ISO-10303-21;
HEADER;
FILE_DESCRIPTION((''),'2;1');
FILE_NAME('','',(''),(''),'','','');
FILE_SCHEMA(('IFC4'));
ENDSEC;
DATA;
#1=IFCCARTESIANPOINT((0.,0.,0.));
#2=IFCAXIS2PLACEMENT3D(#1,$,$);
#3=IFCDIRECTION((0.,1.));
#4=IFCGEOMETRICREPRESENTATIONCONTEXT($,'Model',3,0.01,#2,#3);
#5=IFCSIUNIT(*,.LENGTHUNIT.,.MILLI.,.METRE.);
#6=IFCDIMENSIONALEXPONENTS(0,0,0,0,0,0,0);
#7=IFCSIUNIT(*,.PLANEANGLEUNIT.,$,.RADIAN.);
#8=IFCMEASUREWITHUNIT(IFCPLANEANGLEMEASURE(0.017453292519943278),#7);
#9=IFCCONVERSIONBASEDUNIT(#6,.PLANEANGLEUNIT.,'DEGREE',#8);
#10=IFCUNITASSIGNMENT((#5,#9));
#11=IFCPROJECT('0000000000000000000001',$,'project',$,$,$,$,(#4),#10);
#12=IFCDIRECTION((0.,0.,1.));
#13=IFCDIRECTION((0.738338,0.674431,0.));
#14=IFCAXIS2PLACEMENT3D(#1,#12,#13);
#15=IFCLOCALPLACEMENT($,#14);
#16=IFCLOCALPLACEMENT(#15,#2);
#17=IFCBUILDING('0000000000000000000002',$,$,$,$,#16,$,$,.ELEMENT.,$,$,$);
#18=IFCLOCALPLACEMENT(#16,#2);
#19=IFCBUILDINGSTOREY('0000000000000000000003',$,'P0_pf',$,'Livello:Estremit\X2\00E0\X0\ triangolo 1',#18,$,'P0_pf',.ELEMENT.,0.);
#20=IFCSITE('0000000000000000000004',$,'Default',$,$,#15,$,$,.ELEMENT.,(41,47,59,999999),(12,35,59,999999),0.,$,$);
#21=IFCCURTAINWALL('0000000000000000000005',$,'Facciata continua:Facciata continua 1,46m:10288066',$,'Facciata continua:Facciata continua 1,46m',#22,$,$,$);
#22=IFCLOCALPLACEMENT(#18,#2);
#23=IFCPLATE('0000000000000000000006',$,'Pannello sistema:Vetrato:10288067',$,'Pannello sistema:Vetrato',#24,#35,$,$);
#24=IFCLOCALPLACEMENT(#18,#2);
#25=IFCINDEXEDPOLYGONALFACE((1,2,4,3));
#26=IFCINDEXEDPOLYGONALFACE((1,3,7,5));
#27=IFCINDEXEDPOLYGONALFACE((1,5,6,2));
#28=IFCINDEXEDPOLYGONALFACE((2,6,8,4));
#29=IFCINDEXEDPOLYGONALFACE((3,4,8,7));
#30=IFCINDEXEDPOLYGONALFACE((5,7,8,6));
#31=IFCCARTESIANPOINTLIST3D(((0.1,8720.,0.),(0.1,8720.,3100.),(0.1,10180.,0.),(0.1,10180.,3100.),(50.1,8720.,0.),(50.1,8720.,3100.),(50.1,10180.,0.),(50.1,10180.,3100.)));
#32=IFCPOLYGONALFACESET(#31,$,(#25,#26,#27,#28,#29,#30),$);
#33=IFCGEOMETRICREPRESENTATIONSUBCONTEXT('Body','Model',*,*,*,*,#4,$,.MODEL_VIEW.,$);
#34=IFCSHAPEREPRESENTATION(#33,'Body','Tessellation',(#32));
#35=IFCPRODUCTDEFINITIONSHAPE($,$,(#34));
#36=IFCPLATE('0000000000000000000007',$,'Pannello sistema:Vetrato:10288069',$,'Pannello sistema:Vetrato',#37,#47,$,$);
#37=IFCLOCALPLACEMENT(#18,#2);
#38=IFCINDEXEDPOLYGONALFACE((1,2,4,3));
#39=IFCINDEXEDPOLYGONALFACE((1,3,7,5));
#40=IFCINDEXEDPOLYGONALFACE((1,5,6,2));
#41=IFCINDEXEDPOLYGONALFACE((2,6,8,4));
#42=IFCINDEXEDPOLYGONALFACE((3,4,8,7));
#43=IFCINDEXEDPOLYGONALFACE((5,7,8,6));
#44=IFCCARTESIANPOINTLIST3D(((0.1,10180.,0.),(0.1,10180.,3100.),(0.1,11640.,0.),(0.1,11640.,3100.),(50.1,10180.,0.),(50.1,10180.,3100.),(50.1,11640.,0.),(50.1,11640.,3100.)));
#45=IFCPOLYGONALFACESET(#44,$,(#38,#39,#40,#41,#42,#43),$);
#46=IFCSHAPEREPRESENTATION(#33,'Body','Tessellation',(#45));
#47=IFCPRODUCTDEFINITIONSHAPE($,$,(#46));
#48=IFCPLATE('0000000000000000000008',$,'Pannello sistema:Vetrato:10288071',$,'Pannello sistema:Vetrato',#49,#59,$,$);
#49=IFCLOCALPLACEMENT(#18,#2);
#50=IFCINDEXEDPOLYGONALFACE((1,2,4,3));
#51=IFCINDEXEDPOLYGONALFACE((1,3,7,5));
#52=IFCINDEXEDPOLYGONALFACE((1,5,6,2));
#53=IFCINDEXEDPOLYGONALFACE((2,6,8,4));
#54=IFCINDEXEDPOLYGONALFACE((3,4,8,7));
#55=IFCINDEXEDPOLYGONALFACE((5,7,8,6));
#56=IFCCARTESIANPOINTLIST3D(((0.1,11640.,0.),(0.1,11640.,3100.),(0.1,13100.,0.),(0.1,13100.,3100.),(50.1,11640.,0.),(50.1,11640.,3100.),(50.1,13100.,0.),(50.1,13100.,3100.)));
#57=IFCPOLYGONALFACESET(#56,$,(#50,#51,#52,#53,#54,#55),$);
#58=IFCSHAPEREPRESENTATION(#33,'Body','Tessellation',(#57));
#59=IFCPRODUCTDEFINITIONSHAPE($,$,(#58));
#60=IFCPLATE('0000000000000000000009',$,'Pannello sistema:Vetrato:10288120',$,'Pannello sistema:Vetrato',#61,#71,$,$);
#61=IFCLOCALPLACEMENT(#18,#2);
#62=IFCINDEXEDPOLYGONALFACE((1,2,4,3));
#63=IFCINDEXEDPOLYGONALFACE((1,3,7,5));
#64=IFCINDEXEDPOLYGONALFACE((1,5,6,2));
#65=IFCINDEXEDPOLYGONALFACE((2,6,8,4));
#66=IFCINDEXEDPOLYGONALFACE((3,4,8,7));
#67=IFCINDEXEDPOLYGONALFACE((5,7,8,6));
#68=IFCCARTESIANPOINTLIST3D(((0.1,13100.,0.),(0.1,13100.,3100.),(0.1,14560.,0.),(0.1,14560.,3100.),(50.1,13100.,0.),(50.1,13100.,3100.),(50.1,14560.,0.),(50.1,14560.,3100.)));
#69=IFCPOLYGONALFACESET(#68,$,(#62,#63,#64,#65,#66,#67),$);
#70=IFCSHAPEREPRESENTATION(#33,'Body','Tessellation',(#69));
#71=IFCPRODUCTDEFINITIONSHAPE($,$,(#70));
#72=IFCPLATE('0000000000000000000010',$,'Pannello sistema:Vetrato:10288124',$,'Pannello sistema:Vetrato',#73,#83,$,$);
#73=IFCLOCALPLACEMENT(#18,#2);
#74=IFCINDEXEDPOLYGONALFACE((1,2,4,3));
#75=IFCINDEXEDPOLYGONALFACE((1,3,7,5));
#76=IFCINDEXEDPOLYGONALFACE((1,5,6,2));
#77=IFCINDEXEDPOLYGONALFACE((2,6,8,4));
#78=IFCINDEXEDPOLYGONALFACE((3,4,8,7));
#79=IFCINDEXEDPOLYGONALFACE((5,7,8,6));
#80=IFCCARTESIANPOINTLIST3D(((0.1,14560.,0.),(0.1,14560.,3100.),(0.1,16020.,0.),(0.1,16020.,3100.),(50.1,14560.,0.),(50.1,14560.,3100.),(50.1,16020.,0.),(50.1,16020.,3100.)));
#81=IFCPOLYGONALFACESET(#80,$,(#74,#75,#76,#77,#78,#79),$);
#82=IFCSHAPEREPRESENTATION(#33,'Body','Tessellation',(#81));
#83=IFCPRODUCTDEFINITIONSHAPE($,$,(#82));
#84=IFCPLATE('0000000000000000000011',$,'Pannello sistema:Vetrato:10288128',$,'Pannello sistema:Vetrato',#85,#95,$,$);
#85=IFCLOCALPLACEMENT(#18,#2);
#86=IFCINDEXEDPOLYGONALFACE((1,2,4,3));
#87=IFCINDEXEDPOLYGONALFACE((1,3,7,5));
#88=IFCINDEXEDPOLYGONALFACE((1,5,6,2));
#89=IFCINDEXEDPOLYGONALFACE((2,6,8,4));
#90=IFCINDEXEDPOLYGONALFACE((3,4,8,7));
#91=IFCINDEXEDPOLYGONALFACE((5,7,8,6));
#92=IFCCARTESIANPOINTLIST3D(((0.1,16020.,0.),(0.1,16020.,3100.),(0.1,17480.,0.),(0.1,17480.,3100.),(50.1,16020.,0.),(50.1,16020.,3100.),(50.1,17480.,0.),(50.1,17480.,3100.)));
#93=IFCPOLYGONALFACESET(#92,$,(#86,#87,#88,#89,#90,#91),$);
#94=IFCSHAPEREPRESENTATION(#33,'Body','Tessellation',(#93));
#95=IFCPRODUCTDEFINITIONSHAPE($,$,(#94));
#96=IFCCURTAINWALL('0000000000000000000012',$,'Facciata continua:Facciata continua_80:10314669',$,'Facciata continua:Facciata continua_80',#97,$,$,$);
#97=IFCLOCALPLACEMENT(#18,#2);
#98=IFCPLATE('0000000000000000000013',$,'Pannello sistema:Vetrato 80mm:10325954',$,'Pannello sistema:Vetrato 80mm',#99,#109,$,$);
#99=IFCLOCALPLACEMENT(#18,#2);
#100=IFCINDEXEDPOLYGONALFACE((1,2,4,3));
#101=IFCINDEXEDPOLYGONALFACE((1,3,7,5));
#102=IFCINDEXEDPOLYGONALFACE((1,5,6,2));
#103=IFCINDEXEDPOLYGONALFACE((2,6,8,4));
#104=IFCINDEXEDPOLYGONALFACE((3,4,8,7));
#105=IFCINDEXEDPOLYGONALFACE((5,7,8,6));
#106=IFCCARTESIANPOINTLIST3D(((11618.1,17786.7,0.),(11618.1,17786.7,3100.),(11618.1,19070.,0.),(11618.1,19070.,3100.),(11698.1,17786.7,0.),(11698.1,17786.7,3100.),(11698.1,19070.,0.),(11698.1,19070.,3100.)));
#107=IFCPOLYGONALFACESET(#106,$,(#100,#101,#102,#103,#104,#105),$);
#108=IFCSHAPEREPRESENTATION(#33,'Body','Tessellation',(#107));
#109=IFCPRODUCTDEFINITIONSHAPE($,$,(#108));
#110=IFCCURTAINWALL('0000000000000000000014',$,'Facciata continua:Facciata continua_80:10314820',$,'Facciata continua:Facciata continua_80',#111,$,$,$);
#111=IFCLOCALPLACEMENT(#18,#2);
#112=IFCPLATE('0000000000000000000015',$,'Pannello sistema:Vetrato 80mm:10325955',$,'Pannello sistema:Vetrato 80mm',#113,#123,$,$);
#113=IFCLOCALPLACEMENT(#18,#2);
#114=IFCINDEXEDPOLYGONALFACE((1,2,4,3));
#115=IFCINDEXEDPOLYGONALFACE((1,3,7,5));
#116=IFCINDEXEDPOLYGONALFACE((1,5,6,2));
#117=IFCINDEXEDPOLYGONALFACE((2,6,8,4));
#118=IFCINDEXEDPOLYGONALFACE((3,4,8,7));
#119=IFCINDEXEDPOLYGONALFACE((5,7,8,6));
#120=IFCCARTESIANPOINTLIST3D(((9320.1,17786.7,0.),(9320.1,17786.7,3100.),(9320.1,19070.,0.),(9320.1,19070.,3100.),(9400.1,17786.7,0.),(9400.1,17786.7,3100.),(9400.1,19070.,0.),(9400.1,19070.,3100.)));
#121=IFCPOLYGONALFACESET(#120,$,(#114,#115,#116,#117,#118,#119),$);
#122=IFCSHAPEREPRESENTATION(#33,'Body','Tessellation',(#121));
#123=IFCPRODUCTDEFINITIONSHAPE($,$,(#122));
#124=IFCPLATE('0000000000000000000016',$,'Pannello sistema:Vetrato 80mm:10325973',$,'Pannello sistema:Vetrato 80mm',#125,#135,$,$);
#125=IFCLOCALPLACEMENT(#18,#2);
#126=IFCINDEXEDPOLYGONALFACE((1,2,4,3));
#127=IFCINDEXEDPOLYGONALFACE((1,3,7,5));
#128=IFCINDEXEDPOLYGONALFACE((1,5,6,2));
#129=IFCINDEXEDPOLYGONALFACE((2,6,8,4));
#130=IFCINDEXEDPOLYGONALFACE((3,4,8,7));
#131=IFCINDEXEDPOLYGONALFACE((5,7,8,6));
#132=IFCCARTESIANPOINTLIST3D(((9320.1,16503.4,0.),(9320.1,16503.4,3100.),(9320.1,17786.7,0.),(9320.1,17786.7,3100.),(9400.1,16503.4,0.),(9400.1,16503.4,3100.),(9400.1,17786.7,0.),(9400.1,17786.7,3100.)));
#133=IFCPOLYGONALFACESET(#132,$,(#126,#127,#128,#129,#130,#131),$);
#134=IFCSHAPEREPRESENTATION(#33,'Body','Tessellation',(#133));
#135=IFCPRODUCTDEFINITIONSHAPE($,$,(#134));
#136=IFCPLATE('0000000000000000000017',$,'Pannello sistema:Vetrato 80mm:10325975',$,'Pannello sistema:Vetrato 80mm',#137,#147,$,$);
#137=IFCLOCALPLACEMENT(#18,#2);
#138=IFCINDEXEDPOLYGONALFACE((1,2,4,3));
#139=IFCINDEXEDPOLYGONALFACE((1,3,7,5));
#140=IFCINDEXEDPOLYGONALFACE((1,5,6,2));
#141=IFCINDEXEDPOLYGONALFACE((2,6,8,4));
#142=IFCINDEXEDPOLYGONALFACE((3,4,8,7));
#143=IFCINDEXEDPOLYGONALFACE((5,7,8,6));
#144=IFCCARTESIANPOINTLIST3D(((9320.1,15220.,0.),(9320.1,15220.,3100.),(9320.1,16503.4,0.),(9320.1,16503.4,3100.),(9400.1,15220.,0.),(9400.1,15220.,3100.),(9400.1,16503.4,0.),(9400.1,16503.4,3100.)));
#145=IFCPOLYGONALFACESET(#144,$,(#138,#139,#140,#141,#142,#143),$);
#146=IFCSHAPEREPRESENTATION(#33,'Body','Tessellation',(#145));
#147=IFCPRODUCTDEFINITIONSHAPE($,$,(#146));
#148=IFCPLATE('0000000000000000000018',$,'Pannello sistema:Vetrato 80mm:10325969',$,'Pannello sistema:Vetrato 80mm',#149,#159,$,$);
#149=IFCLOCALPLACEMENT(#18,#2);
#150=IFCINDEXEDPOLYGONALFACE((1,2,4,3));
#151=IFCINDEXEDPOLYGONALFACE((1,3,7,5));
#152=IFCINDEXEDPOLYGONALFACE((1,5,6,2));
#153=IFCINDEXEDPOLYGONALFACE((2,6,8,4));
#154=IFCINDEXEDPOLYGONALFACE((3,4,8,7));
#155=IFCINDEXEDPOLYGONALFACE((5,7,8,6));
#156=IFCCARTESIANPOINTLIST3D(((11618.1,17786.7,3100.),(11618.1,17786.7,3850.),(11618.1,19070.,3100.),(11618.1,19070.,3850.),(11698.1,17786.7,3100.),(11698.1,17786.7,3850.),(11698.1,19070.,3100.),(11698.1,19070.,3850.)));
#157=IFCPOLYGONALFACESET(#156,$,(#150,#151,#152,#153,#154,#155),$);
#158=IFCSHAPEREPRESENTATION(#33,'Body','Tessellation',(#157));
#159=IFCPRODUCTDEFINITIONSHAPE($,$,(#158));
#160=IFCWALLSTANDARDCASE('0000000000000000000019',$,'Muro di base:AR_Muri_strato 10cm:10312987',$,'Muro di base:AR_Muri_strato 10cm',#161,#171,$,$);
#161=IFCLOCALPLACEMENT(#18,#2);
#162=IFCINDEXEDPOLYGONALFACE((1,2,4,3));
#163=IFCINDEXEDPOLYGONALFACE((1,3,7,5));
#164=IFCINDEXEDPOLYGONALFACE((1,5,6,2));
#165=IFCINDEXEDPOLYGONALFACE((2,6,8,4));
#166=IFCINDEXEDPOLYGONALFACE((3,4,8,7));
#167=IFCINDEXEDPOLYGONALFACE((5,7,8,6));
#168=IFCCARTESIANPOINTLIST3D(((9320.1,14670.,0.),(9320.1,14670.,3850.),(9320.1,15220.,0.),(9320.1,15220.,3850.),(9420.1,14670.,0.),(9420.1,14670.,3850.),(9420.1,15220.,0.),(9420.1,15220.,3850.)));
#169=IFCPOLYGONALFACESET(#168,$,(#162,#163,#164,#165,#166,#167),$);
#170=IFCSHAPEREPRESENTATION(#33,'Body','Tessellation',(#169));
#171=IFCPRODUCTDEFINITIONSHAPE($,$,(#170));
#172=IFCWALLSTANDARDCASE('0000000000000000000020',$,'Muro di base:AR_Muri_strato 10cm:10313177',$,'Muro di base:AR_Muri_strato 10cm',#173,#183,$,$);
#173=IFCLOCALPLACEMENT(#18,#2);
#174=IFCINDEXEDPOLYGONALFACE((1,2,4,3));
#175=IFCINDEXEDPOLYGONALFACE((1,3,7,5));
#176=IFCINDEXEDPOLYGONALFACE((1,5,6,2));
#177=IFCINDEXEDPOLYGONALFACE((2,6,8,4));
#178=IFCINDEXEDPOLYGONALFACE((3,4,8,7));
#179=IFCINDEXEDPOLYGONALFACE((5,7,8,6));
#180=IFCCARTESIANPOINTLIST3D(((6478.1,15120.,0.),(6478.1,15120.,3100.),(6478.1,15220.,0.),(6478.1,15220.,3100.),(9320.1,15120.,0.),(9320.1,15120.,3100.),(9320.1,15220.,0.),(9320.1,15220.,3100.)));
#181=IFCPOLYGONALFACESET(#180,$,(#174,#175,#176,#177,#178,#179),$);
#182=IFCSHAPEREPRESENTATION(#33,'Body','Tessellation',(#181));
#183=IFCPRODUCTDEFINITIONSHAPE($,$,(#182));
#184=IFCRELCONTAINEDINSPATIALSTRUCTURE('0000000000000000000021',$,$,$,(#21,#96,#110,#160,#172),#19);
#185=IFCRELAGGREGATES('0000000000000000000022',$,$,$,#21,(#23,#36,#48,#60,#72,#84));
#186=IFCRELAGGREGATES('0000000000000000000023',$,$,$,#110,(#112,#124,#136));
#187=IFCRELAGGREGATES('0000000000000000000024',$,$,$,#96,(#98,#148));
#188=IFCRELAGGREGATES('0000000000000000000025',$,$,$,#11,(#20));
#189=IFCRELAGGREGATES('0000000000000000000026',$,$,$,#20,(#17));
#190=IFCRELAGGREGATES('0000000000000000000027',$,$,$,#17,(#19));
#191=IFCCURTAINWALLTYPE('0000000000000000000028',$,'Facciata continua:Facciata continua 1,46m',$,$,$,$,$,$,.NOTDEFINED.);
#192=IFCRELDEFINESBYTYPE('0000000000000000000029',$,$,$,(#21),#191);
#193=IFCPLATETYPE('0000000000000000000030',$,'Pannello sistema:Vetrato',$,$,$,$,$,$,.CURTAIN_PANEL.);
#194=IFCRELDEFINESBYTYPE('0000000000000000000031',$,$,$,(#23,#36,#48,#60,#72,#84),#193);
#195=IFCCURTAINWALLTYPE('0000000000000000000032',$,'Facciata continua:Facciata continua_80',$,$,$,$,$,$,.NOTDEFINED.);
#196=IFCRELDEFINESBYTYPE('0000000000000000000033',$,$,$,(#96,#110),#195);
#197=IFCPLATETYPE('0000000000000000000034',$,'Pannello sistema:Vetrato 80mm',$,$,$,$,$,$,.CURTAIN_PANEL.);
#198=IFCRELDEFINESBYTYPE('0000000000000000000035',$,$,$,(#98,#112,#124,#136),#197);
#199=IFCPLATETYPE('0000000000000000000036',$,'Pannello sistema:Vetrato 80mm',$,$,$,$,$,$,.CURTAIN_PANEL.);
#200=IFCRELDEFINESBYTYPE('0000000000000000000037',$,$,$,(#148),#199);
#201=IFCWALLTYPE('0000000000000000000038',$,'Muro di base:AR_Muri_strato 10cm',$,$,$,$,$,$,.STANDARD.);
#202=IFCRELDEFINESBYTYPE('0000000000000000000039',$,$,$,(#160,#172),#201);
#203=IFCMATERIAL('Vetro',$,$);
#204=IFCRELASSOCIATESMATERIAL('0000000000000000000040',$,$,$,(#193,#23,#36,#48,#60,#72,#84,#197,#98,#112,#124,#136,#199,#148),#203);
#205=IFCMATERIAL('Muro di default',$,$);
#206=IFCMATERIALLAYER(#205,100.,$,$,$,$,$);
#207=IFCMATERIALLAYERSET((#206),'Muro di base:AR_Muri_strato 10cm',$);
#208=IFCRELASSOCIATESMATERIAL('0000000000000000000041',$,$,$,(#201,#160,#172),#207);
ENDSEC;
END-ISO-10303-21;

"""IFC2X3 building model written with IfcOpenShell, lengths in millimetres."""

from ifc_helpers import new_model, entity, si_unit, converted_unit, direction, frame, frame_2d, origin, origin_2d_with_axis, place, context, subcontext, project, spatial, rectangle, extrude, source, transform, mapped, material, layer, layer_set, layer_usage, type_object, type_shapes, element, aggregate, save


model = new_model("IFC2X3")

# Units and contexts
model_context = context("Model", 3, precision=0.01, world=origin(), true_north=direction((0.0, 1.0)))
body_context = subcontext(model_context, "Body", "Model", "MODEL_VIEW")
ifc_project = project(units=[si_unit("LENGTHUNIT", "METRE", prefix="MILLI"), converted_unit("PLANEANGLEUNIT", "DEGREE", entity("IfcPlaneAngleMeasure", 0.017453292519943278), si_unit("PLANEANGLEUNIT", "RADIAN"), dimensions=[0, 0, 0, 0, 0, 0, 0])], contexts=[model_context])

# Site, building, storey
site_placement = place(None, frame((0.0, 0.0, 0.0), z_axis=(0.0, 0.0, 1.0), x_axis=(0.738338, 0.674431, 0.0)))
site = spatial("IfcSite", under=ifc_project, at=site_placement, Name="Default", CompositionType="ELEMENT", RefLatitude=(41, 47, 59, 999999), RefLongitude=(12, 35, 59, 999999), RefElevation=0.0)
building_placement = place(site_placement, origin())
building = spatial("IfcBuilding", under=site, at=building_placement, CompositionType="ELEMENT")
storey_placement = place(building_placement, origin())
storey = spatial("IfcBuildingStorey", under=building, at=storey_placement, Name="P0_pf", ObjectType="Livello:Estremità triangolo 1", LongName="P0_pf", CompositionType="ELEMENT", Elevation=0.0)

# Curtain wall, plates
curtain_wall_type_1 = type_object("IfcCurtainWallType", Name="Facciata continua:Facciata continua 1,46m", PredefinedType="NOTDEFINED")
curtain_wall_1_placement = place(storey_placement, origin())
curtain_wall_1 = element("IfcCurtainWall", 1, at=curtain_wall_1_placement, inside=storey, type_object=curtain_wall_type_1, Name="Facciata continua:Facciata continua 1,46m:10288066", ObjectType="Facciata continua:Facciata continua 1,46m")
ifc_material_1 = material(Name="Vetro")
plate_type_1 = type_object("IfcPlateType", Name="Pannello sistema:Vetrato", PredefinedType="CURTAIN_PANEL", material=ifc_material_1)
shared_shape_1 = source(origin(), body_context, "Body", "SweptSolid", [
    extrude(rectangle(XDim=50.0, YDim=1460.0, at=origin_2d_with_axis()), frame((0.0, -25.0, 0.0), z_axis=(0.0, 0.0, 1.0), x_axis=(0.0, 1.0, 0.0)), (0.0, 0.0, 1.0), 3100.0),
])
type_shapes(plate_type_1, [shared_shape_1])
plate_1_placement = place(curtain_wall_1_placement, frame((0.1, 9450.0, 0.0), z_axis=(0.0, 0.0, 1.0), x_axis=(0.0, 1.0, 0.0)))
plate_1 = element("IfcPlate", 2, at=plate_1_placement, type_object=plate_type_1, material=ifc_material_1, Name="Pannello sistema:Vetrato:10288067", ObjectType="Pannello sistema:Vetrato", context=body_context, shape_type="MappedRepresentation", body=[
    mapped(shared_shape_1, transform((0.0, 0.0, 0.0), scale=1.0)),
])
plate_2_placement = place(curtain_wall_1_placement, frame((0.1, 10910.0, 0.0), z_axis=(0.0, 0.0, 1.0), x_axis=(0.0, 1.0, 0.0)))
plate_2 = element("IfcPlate", 3, at=plate_2_placement, type_object=plate_type_1, material=ifc_material_1, Name="Pannello sistema:Vetrato:10288069", ObjectType="Pannello sistema:Vetrato", context=body_context, shape_type="MappedRepresentation", body=[
    mapped(shared_shape_1, transform((0.0, 0.0, 0.0), scale=1.0)),
])
plate_3_placement = place(curtain_wall_1_placement, frame((0.1, 12370.0, 0.0), z_axis=(0.0, 0.0, 1.0), x_axis=(0.0, 1.0, 0.0)))
plate_3 = element("IfcPlate", 4, at=plate_3_placement, type_object=plate_type_1, material=ifc_material_1, Name="Pannello sistema:Vetrato:10288071", ObjectType="Pannello sistema:Vetrato", context=body_context, shape_type="MappedRepresentation", body=[
    mapped(shared_shape_1, transform((0.0, 0.0, 0.0), scale=1.0)),
])
plate_4_placement = place(curtain_wall_1_placement, frame((0.1, 13830.0, 0.0), z_axis=(0.0, 0.0, 1.0), x_axis=(0.0, 1.0, 0.0)))
plate_4 = element("IfcPlate", 5, at=plate_4_placement, type_object=plate_type_1, material=ifc_material_1, Name="Pannello sistema:Vetrato:10288120", ObjectType="Pannello sistema:Vetrato", context=body_context, shape_type="MappedRepresentation", body=[
    mapped(shared_shape_1, transform((0.0, 0.0, 0.0), scale=1.0)),
])
plate_5_placement = place(curtain_wall_1_placement, frame((0.1, 15290.0, 0.0), z_axis=(0.0, 0.0, 1.0), x_axis=(0.0, 1.0, 0.0)))
plate_5 = element("IfcPlate", 6, at=plate_5_placement, type_object=plate_type_1, material=ifc_material_1, Name="Pannello sistema:Vetrato:10288124", ObjectType="Pannello sistema:Vetrato", context=body_context, shape_type="MappedRepresentation", body=[
    mapped(shared_shape_1, transform((0.0, 0.0, 0.0), scale=1.0)),
])
plate_6_placement = place(curtain_wall_1_placement, frame((0.1, 16750.0, 0.0), z_axis=(0.0, 0.0, 1.0), x_axis=(0.0, 1.0, 0.0)))
plate_6 = element("IfcPlate", 7, at=plate_6_placement, type_object=plate_type_1, material=ifc_material_1, Name="Pannello sistema:Vetrato:10288128", ObjectType="Pannello sistema:Vetrato", context=body_context, shape_type="MappedRepresentation", body=[
    mapped(shared_shape_1, transform((0.0, 0.0, 0.0), scale=1.0)),
])
aggregate(curtain_wall_1, [plate_1, plate_2, plate_3, plate_4, plate_5, plate_6])

# Curtain wall, plate
curtain_wall_type_2 = type_object("IfcCurtainWallType", Name="Facciata continua:Facciata continua_80", PredefinedType="NOTDEFINED")
curtain_wall_2_placement = place(storey_placement, origin())
curtain_wall_2 = element("IfcCurtainWall", 8, at=curtain_wall_2_placement, inside=storey, type_object=curtain_wall_type_2, Name="Facciata continua:Facciata continua_80:10314669", ObjectType="Facciata continua:Facciata continua_80")
plate_type_2 = type_object("IfcPlateType", Name="Pannello sistema:Vetrato 80mm", PredefinedType="CURTAIN_PANEL", material=ifc_material_1)
shared_shape_2 = source(origin(), body_context, "Body", "SweptSolid", [
    extrude(rectangle(XDim=80.0, YDim=1283.3, at=origin_2d_with_axis()), frame((0.0, -40.0, 0.0), z_axis=(0.0, 0.0, 1.0), x_axis=(0.0, 1.0, 0.0)), (0.0, 0.0, 1.0), 3100.0),
])
type_shapes(plate_type_2, [shared_shape_2])
plate_7_placement = place(curtain_wall_2_placement, frame((11698.1, 18428.4, 0.0), z_axis=(0.0, 0.0, 1.0), x_axis=(0.0, -1.0, 0.0)))
plate_7 = element("IfcPlate", 9, at=plate_7_placement, type_object=plate_type_2, material=ifc_material_1, Name="Pannello sistema:Vetrato 80mm:10325954", ObjectType="Pannello sistema:Vetrato 80mm", context=body_context, shape_type="MappedRepresentation", body=[
    mapped(shared_shape_2, transform((0.0, 0.0, 0.0), scale=1.0)),
])

# Curtain wall, plates
curtain_wall_3_placement = place(storey_placement, origin())
curtain_wall_3 = element("IfcCurtainWall", 10, at=curtain_wall_3_placement, inside=storey, type_object=curtain_wall_type_2, Name="Facciata continua:Facciata continua_80:10314820", ObjectType="Facciata continua:Facciata continua_80")
plate_8_placement = place(curtain_wall_3_placement, frame((9400.1, 18428.4, 0.0), z_axis=(0.0, 0.0, 1.0), x_axis=(0.0, -1.0, 0.0)))
plate_8 = element("IfcPlate", 11, at=plate_8_placement, type_object=plate_type_2, material=ifc_material_1, Name="Pannello sistema:Vetrato 80mm:10325955", ObjectType="Pannello sistema:Vetrato 80mm", context=body_context, shape_type="MappedRepresentation", body=[
    mapped(shared_shape_2, transform((0.0, 0.0, 0.0), scale=1.0)),
])
plate_9_placement = place(curtain_wall_3_placement, frame((9400.1, 17145.0, 0.0), z_axis=(0.0, 0.0, 1.0), x_axis=(0.0, -1.0, 0.0)))
plate_9 = element("IfcPlate", 12, at=plate_9_placement, type_object=plate_type_2, material=ifc_material_1, Name="Pannello sistema:Vetrato 80mm:10325973", ObjectType="Pannello sistema:Vetrato 80mm", context=body_context, shape_type="MappedRepresentation", body=[
    mapped(shared_shape_2, transform((0.0, 0.0, 0.0), scale=1.0)),
])
plate_10_placement = place(curtain_wall_3_placement, frame((9400.1, 15861.7, 0.0), z_axis=(0.0, 0.0, 1.0), x_axis=(0.0, -1.0, 0.0)))
plate_10 = element("IfcPlate", 13, at=plate_10_placement, type_object=plate_type_2, material=ifc_material_1, Name="Pannello sistema:Vetrato 80mm:10325975", ObjectType="Pannello sistema:Vetrato 80mm", context=body_context, shape_type="MappedRepresentation", body=[
    mapped(shared_shape_2, transform((0.0, 0.0, 0.0), scale=1.0)),
])
aggregate(curtain_wall_3, [plate_8, plate_9, plate_10])

# Plate
plate_type_3 = type_object("IfcPlateType", Name="Pannello sistema:Vetrato 80mm", PredefinedType="CURTAIN_PANEL", material=ifc_material_1)
shared_shape_3 = source(origin(), body_context, "Body", "SweptSolid", [
    extrude(rectangle(XDim=80.0, YDim=1283.3, at=frame_2d((0.0, 0.0), x_axis=(1.0, 0.0))), frame((0.0, -40.0, 0.0), z_axis=(0.0, 0.0, 1.0), x_axis=(0.0, 1.0, 0.0)), (0.0, 0.0, 1.0), 750.0),
])
type_shapes(plate_type_3, [shared_shape_3])
plate_11_placement = place(curtain_wall_2_placement, frame((11698.1, 18428.4, 3100.0), z_axis=(0.0, 0.0, 1.0), x_axis=(0.0, -1.0, 0.0)))
plate_11 = element("IfcPlate", 14, at=plate_11_placement, type_object=plate_type_3, material=ifc_material_1, Name="Pannello sistema:Vetrato 80mm:10325969", ObjectType="Pannello sistema:Vetrato 80mm", context=body_context, shape_type="MappedRepresentation", body=[
    mapped(shared_shape_3, transform((0.0, 0.0, 0.0), scale=1.0)),
])
aggregate(curtain_wall_2, [plate_7, plate_11])

# Walls
ifc_material_2 = material(Name="Muro di default")
ifc_layer_1 = layer(ifc_material_2, 100.0)
ifc_layer_set_1 = layer_set([ifc_layer_1], Name="Muro di base:AR_Muri_strato 10cm")
ifc_layer_usage_1 = layer_usage(ifc_layer_set_1, "AXIS2", "NEGATIVE", 50.0)
wall_type_1 = type_object("IfcWallType", Name="Muro di base:AR_Muri_strato 10cm", PredefinedType="STANDARD", material=ifc_layer_set_1)
wall_1_placement = place(storey_placement, frame((9370.1, 15220.0, 0.0), z_axis=(0.0, 0.0, 1.0), x_axis=(0.0, -1.0, 0.0)))
element("IfcWallStandardCase", 15, at=wall_1_placement, inside=storey, type_object=wall_type_1, material=ifc_layer_usage_1, Name="Muro di base:AR_Muri_strato 10cm:10312987", ObjectType="Muro di base:AR_Muri_strato 10cm", context=body_context, shape_type="SweptSolid", body=[
    extrude(rectangle(XDim=550.0, YDim=100.0, at=frame_2d((275.0, 0.0), x_axis=(-1.0, 0.0))), origin(), (0.0, 0.0, 1.0), 3850.0),
])
ifc_layer_usage_2 = layer_usage(ifc_layer_set_1, "AXIS2", "NEGATIVE", 50.0)
wall_2_placement = place(storey_placement, frame((6478.1, 15170.0, 0.0)))
element("IfcWallStandardCase", 16, at=wall_2_placement, inside=storey, type_object=wall_type_1, material=ifc_layer_usage_2, Name="Muro di base:AR_Muri_strato 10cm:10313177", ObjectType="Muro di base:AR_Muri_strato 10cm", context=body_context, shape_type="SweptSolid", body=[
    extrude(rectangle(XDim=2842.0, YDim=100.0, at=frame_2d((1421.0, 0.0), x_axis=(-1.0, 0.0))), origin(), (0.0, 0.0, 1.0), 3100.0),
])

save(model, "model.ifc")
